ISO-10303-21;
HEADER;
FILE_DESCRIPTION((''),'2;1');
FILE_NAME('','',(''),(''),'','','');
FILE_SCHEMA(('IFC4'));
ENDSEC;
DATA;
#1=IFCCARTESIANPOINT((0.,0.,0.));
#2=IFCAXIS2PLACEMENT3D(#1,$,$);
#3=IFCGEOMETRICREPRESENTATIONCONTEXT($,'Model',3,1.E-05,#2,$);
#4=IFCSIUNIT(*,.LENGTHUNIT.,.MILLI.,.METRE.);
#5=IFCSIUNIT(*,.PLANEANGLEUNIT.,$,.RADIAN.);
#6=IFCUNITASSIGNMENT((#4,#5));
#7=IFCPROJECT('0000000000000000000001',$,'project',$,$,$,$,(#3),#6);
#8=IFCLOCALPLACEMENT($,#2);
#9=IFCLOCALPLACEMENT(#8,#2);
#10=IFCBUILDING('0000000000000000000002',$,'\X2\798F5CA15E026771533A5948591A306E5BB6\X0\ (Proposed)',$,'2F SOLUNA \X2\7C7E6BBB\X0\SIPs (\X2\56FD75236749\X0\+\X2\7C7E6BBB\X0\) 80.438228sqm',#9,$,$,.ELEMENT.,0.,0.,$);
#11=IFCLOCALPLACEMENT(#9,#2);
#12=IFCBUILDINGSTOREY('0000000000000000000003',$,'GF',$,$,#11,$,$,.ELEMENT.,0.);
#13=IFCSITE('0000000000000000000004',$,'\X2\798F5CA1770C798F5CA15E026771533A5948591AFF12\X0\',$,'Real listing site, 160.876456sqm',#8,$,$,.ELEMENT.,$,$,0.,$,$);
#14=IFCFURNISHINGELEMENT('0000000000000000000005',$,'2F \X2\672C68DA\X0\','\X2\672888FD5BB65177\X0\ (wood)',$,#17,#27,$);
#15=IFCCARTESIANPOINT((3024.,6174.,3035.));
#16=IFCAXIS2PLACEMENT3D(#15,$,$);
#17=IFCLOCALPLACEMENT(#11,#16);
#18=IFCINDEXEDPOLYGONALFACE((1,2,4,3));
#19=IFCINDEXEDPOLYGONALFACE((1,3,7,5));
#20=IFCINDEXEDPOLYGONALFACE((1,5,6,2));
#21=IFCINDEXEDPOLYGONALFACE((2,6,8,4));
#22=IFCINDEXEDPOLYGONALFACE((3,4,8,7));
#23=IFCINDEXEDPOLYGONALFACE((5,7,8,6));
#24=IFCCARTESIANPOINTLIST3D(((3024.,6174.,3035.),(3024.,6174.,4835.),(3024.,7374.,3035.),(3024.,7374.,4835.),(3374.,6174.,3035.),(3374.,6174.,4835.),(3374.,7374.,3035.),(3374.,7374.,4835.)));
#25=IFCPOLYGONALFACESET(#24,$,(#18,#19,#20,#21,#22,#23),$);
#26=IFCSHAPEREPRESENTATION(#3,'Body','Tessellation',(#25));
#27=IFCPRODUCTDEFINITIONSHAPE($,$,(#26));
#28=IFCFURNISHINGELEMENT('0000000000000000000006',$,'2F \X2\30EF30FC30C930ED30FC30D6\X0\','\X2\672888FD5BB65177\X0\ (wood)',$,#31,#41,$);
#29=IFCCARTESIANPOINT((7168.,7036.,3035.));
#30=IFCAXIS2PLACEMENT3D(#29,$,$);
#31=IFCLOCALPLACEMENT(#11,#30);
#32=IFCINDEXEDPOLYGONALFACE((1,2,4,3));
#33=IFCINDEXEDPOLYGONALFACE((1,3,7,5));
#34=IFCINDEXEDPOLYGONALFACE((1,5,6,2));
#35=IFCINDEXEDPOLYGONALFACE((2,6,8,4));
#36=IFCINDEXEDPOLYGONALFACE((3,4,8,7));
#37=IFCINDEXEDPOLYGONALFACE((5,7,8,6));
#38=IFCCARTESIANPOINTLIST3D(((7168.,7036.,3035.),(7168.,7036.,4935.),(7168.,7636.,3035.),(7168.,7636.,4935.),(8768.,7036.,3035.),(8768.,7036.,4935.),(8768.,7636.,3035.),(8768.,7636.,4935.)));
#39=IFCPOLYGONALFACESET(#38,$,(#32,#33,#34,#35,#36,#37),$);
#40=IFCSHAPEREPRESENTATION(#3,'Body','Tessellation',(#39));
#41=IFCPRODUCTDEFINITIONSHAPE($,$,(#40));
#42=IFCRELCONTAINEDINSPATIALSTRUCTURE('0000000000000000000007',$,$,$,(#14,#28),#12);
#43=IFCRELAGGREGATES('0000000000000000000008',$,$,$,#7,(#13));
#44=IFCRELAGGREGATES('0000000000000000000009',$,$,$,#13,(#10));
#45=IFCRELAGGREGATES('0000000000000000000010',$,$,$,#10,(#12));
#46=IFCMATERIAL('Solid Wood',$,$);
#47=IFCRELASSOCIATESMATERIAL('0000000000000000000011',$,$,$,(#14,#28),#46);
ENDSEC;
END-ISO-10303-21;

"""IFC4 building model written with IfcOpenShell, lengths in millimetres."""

from ifc_helpers import new_model, si_unit, frame, frame_2d, origin, place, context, project, spatial, rectangle, extrude, material, element, save


model = new_model("IFC4")

# Units and contexts
model_context = context("Model", 3, precision=1e-05, world=origin())
ifc_project = project(units=[si_unit("LENGTHUNIT", "METRE", prefix="MILLI"), si_unit("PLANEANGLEUNIT", "RADIAN")], contexts=[model_context])

# Site, building, storey
site_placement = place(None, origin())
site = spatial("IfcSite", under=ifc_project, at=site_placement, Name="福岡県福岡市東区奈多２", ObjectType="Real listing site, 160.876456sqm", CompositionType="ELEMENT", RefElevation=0.0)
building_placement = place(site_placement, origin())
building = spatial("IfcBuilding", under=site, at=building_placement, Name="福岡市東区奈多の家 (Proposed)", ObjectType="2F SOLUNA 籾殻SIPs (国産杉+籾殻) 80.438228sqm", CompositionType="ELEMENT", ElevationOfRefHeight=0.0, ElevationOfTerrain=0.0)
storey_placement = place(building_placement, origin())
storey = spatial("IfcBuildingStorey", under=building, at=storey_placement, Name="GF", CompositionType="ELEMENT", Elevation=0.0)

# Shared definitions
ifc_material_1 = material(Name="Solid Wood")

# Furnishing elements
furnishing_1_placement = place(storey_placement, frame((3024.0, 6174.0, 3035.0)))
element("IfcFurnishingElement", 1, at=furnishing_1_placement, inside=storey, material=ifc_material_1, Name="2F 本棚", Description="木製家具 (wood)", context=model_context, shape_type="SweptSolid", body=[
    extrude(rectangle(XDim=350.0, YDim=1200.0, at=frame_2d((175.0, 600.0))), frame((3024.0, 6174.0, 3035.0)), (0.0, 0.0, 1.0), 1800.0),
])
furnishing_2_placement = place(storey_placement, frame((7168.0, 7036.0, 3035.0)))
element("IfcFurnishingElement", 2, at=furnishing_2_placement, inside=storey, material=ifc_material_1, Name="2F ワードローブ", Description="木製家具 (wood)", context=model_context, shape_type="SweptSolid", body=[
    extrude(rectangle(XDim=1600.0, YDim=600.0, at=frame_2d((800.0, 300.0))), frame((7168.0, 7036.0, 3035.0)), (0.0, 0.0, 1.0), 1900.0),
])

save(model, "model.ifc")
